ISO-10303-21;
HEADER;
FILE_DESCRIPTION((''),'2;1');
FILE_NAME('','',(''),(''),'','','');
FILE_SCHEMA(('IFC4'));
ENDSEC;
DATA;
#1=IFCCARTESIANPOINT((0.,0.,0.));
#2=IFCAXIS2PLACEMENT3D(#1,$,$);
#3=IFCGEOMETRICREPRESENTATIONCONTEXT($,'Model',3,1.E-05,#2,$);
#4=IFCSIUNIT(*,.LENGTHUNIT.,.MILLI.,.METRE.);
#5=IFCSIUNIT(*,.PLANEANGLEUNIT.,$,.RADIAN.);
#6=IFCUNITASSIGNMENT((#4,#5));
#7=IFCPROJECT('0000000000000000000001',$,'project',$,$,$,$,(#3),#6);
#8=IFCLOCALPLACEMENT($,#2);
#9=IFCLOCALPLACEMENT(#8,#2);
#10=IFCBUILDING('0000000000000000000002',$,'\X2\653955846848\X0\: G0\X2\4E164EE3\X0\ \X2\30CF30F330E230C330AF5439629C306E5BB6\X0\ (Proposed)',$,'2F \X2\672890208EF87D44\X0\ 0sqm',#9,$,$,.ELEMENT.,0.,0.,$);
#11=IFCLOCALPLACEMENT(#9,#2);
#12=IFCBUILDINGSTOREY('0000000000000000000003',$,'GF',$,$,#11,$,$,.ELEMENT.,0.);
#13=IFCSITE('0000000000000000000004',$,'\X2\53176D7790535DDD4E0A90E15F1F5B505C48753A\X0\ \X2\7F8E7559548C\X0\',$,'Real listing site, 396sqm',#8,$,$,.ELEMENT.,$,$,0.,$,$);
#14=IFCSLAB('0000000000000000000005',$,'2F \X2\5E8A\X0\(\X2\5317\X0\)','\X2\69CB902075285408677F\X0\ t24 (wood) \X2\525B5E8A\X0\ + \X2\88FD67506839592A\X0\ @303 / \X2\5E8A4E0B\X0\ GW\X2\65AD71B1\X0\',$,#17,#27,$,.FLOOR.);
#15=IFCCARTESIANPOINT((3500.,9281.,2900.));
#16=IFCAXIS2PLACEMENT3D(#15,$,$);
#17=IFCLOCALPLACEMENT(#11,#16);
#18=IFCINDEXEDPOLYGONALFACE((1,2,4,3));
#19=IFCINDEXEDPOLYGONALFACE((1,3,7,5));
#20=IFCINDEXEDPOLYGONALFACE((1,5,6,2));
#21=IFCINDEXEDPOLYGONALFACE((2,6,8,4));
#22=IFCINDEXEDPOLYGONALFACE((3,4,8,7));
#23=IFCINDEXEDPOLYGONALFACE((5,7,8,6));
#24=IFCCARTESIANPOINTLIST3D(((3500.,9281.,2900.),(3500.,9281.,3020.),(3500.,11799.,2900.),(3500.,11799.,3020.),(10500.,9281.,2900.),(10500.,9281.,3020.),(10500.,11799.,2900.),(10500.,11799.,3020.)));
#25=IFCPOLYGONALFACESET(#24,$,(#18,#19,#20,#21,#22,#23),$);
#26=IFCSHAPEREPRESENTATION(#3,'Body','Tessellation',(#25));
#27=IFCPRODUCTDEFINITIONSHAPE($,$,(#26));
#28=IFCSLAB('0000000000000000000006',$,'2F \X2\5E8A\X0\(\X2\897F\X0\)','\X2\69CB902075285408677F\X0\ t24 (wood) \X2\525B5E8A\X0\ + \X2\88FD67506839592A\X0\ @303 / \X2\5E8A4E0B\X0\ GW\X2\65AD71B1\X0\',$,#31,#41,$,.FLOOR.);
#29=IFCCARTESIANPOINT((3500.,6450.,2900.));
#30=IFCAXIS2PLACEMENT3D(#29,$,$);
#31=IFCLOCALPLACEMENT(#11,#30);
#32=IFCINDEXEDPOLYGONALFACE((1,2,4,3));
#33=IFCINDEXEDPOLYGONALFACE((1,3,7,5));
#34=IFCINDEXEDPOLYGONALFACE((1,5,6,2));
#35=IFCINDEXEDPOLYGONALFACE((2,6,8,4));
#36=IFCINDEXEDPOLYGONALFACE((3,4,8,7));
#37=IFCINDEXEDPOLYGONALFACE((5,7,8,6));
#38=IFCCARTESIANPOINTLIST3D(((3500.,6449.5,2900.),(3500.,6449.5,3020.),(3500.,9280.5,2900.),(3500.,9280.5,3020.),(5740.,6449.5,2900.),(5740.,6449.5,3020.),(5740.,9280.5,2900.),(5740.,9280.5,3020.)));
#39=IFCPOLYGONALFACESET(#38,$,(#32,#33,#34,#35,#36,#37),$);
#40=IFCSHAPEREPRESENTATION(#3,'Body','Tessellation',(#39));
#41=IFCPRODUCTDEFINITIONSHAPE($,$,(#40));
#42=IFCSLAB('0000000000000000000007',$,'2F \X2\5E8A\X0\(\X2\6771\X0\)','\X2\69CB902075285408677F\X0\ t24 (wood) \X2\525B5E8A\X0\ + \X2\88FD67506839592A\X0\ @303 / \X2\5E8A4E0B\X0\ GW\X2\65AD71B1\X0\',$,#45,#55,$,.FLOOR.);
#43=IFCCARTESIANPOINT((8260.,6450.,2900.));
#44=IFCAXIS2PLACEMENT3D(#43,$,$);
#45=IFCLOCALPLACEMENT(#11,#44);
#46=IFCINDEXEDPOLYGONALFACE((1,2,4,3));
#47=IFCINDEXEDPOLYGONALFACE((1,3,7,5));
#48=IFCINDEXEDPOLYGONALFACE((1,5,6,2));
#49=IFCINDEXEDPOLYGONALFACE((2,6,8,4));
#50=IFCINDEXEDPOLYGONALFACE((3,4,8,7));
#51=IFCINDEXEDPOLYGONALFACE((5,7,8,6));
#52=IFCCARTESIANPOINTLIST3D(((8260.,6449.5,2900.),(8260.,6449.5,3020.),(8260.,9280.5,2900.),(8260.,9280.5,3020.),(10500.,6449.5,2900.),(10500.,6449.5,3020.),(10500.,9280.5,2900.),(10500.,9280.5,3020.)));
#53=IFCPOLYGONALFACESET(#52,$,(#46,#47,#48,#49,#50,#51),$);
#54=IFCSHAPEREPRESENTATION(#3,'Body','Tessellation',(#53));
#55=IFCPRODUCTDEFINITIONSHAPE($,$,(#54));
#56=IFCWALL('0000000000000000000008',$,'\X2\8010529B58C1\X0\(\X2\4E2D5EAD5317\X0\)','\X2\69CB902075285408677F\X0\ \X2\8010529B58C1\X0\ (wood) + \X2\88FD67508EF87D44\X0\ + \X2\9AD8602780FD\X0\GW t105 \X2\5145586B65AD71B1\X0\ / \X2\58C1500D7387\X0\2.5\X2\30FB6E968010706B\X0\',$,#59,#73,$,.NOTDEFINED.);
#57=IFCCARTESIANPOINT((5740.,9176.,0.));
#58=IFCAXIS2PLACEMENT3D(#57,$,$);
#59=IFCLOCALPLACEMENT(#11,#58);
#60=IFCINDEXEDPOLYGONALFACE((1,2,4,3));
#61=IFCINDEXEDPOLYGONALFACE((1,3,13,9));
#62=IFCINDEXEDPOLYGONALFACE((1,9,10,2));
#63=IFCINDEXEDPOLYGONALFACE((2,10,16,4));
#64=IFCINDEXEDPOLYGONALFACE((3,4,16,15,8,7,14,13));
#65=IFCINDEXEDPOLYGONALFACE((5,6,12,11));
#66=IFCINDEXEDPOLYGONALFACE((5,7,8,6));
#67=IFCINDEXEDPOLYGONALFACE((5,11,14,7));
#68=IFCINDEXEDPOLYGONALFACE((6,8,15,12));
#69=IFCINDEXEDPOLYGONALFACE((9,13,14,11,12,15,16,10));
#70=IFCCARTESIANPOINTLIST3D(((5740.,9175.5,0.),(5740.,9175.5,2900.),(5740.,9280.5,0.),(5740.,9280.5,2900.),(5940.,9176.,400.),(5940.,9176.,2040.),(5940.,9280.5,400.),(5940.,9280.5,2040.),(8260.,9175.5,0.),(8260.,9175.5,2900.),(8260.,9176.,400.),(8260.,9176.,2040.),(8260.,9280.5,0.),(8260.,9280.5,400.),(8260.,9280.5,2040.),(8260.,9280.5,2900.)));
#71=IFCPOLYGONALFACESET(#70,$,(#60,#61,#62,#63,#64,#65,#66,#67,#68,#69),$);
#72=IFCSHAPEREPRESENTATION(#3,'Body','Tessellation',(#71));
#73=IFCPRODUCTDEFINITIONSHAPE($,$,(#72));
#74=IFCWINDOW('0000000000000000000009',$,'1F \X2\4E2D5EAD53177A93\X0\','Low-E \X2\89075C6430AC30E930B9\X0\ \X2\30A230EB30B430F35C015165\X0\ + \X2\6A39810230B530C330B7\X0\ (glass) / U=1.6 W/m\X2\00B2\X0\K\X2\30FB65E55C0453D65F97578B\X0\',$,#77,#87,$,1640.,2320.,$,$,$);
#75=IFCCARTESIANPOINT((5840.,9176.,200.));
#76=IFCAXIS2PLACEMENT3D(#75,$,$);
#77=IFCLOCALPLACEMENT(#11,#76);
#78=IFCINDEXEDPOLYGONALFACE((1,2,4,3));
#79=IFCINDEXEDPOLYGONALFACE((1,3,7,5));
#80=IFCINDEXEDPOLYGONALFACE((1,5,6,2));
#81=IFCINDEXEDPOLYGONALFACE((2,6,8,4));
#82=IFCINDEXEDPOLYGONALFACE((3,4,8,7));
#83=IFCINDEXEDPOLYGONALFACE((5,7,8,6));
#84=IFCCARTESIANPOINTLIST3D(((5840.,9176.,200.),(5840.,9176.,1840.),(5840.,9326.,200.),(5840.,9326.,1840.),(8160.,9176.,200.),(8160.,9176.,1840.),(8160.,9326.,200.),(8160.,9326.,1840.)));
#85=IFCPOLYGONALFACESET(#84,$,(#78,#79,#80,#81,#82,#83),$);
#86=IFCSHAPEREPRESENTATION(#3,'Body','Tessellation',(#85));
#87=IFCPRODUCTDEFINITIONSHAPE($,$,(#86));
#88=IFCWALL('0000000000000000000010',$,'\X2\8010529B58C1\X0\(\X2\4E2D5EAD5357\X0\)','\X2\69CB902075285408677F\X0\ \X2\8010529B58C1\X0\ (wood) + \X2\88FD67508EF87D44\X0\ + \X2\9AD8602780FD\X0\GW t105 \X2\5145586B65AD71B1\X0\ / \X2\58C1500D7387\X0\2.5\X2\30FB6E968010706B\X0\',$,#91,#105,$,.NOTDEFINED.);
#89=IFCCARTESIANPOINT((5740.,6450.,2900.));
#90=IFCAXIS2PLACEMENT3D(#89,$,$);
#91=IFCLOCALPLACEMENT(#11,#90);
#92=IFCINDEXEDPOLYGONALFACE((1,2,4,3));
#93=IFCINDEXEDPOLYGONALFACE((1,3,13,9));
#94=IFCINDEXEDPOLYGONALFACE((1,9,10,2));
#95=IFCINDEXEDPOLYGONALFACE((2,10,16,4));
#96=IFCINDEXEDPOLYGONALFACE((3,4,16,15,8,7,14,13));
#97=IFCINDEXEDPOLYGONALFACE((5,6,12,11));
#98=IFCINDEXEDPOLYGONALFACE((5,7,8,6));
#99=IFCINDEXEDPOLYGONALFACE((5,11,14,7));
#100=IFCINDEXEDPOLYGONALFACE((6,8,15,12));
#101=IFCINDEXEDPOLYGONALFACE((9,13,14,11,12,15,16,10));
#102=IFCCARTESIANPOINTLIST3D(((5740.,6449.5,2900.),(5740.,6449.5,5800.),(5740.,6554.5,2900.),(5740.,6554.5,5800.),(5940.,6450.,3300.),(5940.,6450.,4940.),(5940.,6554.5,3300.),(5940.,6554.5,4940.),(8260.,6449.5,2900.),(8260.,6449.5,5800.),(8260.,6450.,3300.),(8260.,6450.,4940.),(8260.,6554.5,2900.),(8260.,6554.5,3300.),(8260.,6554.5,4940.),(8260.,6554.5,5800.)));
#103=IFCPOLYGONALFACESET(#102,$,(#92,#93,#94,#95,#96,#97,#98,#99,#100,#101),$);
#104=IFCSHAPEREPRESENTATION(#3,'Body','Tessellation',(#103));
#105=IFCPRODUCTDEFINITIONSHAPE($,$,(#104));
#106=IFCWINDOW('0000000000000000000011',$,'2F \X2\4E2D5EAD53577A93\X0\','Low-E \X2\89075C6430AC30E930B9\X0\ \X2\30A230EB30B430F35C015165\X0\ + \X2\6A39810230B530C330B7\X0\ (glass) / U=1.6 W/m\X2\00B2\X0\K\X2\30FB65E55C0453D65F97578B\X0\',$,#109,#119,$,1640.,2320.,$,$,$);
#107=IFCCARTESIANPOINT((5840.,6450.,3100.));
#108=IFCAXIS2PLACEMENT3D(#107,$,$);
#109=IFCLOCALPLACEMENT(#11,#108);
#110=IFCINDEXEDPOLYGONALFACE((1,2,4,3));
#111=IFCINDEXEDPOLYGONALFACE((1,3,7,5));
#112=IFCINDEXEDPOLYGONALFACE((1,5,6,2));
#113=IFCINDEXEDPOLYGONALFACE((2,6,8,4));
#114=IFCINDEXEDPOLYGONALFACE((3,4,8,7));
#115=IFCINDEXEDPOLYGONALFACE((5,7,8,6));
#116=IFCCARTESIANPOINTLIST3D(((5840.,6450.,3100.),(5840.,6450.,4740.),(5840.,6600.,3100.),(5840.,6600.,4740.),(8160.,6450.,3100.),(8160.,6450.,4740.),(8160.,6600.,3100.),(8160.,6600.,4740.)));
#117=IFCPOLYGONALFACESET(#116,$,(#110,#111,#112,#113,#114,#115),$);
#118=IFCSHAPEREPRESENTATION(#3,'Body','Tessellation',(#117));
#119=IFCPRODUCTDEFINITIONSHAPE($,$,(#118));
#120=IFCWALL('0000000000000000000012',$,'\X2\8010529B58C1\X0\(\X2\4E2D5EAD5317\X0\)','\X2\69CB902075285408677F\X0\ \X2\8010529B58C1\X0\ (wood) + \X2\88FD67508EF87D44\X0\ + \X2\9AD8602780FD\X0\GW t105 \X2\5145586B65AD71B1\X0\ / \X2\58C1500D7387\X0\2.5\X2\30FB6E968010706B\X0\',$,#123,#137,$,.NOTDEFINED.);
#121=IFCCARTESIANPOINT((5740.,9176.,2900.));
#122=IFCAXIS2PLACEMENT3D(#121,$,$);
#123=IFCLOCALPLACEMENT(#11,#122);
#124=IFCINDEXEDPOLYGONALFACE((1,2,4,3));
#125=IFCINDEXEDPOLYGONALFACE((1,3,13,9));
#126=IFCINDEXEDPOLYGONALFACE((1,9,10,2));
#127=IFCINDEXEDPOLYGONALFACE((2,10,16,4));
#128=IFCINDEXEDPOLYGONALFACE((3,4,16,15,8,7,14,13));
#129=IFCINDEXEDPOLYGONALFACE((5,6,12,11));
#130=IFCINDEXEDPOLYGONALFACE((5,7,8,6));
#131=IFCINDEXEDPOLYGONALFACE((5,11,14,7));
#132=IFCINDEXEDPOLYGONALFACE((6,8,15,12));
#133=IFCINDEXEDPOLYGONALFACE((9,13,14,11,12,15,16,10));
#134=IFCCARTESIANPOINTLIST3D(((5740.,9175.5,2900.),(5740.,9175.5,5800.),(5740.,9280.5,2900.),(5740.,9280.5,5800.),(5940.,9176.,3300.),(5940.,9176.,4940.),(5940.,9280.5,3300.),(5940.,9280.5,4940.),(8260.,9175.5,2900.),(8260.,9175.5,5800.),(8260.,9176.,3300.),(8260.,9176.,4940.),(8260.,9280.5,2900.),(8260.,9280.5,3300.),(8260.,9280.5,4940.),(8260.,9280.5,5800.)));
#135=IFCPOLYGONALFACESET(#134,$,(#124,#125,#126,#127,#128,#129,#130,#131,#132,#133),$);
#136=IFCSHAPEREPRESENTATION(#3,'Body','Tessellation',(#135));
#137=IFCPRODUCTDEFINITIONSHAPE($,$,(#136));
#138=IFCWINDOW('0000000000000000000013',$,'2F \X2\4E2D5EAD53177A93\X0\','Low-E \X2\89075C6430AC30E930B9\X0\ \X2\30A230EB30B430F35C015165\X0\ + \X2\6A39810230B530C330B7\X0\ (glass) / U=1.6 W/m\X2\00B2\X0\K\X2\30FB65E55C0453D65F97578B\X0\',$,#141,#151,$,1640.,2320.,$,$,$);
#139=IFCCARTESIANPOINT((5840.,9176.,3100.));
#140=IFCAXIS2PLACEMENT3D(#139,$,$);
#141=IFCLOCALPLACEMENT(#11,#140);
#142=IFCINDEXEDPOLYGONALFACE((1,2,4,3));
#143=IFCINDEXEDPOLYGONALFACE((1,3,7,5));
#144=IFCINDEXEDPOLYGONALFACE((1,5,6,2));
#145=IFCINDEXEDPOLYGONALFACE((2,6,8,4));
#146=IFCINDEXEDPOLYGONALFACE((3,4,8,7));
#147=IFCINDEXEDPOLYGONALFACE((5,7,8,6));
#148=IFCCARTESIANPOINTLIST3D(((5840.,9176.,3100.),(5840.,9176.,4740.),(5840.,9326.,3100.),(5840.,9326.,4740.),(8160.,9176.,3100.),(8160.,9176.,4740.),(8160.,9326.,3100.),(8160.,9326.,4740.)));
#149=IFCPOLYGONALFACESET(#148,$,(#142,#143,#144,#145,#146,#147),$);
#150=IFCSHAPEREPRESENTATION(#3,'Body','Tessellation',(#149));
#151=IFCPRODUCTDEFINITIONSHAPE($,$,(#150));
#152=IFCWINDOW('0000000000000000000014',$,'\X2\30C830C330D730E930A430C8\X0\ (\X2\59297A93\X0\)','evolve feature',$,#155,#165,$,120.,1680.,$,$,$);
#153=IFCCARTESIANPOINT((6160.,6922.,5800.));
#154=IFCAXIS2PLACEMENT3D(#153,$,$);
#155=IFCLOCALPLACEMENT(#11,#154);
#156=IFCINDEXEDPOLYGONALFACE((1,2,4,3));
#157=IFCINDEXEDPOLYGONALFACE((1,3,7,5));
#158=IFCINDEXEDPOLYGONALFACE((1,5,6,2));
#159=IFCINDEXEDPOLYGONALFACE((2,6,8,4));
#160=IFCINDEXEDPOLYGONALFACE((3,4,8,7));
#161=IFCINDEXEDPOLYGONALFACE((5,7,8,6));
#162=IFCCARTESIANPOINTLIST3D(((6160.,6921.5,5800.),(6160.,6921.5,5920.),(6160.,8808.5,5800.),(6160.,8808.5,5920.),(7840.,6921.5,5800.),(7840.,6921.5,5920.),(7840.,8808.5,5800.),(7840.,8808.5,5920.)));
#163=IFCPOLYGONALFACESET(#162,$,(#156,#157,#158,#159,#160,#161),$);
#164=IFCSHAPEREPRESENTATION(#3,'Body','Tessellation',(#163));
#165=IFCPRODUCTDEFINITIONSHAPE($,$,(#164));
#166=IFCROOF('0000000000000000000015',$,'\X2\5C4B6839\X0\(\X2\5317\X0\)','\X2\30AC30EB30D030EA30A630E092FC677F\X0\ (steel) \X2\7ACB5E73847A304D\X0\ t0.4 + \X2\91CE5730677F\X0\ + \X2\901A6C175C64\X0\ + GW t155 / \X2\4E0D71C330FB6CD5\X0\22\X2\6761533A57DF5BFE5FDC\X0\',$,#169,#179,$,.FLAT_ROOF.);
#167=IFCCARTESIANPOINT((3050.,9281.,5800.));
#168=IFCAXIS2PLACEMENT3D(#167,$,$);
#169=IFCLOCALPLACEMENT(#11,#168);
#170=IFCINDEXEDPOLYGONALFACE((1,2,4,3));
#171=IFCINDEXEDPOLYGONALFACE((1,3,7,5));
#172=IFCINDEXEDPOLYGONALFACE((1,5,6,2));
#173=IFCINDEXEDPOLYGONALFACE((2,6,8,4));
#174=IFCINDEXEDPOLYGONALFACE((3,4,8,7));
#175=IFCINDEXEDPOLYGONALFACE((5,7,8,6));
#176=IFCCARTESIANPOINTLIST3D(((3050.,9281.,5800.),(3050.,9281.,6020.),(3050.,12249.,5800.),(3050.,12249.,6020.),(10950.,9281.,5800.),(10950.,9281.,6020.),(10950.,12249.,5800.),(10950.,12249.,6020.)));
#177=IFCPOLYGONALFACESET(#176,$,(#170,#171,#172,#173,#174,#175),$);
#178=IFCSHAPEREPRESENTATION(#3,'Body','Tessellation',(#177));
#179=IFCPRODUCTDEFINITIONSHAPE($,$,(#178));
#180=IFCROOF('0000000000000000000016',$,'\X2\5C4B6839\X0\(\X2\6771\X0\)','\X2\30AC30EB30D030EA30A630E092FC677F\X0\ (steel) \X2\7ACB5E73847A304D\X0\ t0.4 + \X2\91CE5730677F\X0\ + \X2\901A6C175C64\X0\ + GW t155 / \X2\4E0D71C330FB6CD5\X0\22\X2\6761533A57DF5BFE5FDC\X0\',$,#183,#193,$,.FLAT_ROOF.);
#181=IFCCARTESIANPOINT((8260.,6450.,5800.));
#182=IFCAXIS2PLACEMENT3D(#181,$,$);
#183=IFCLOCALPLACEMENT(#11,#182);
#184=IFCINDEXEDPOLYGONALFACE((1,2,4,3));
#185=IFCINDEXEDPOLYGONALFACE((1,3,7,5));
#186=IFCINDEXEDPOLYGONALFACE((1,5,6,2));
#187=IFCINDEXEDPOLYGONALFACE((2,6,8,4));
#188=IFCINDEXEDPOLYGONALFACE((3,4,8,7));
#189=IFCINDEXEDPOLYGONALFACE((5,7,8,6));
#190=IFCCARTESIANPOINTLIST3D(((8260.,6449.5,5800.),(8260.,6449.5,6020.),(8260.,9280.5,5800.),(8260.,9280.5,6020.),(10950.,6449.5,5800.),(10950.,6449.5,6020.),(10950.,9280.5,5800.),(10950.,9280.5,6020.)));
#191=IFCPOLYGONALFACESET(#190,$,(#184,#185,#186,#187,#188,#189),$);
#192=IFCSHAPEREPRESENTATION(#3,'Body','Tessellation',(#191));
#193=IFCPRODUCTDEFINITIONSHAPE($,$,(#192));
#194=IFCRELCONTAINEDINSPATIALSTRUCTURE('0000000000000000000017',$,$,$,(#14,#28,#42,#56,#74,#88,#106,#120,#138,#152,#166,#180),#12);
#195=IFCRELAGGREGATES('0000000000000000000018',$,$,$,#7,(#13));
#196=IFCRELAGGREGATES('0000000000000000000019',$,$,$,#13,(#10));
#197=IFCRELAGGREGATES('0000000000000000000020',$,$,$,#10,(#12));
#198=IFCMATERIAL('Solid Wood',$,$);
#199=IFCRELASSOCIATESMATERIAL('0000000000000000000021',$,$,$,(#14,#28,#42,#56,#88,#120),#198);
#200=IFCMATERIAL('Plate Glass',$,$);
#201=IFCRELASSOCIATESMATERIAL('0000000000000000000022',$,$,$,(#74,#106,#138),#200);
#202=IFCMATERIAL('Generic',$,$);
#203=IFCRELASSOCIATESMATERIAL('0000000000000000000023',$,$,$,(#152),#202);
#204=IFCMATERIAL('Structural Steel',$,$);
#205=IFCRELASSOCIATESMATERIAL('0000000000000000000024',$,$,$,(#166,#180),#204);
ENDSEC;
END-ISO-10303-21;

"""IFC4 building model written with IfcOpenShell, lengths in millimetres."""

from ifc_helpers import new_model, si_unit, frame, frame_2d, origin, place, context, project, spatial, rectangle, extrude, material, element, fill, save


model = new_model("IFC4")

# Units and contexts
model_context = context("Model", 3, precision=1e-05, world=origin())
ifc_project = project(units=[si_unit("LENGTHUNIT", "METRE", prefix="MILLI"), si_unit("PLANEANGLEUNIT", "RADIAN")], contexts=[model_context])

# Site, building, storey
site_placement = place(None, origin())
site = spatial("IfcSite", under=ifc_project, at=site_placement, Name="北海道川上郡弟子屈町 美留和", ObjectType="Real listing site, 396sqm", CompositionType="ELEMENT", RefElevation=0.0)
building_placement = place(site_placement, origin())
building = spatial("IfcBuilding", under=site, at=building_placement, Name="改善案: G0世代 ハンモック吹抜の家 (Proposed)", ObjectType="2F 木造軸組 0sqm", CompositionType="ELEMENT", ElevationOfRefHeight=0.0, ElevationOfTerrain=0.0)
storey_placement = place(building_placement, origin())
storey = spatial("IfcBuildingStorey", under=building, at=storey_placement, Name="GF", CompositionType="ELEMENT", Elevation=0.0)

# Slabs
ifc_material_1 = material(Name="Solid Wood")
slab_1_placement = place(storey_placement, frame((3500.0, 9281.0, 2900.0)))
element("IfcSlab", 1, at=slab_1_placement, inside=storey, material=ifc_material_1, Name="2F 床(北)", Description="構造用合板 t24 (wood) 剛床 + 製材根太 @303 / 床下 GW断熱", PredefinedType="FLOOR", context=model_context, shape_type="SweptSolid", body=[
    extrude(rectangle(XDim=7000.0, YDim=2518.0, at=frame_2d((3500.0, 1259.0))), frame((3500.0, 9281.0, 2900.0)), (0.0, 0.0, 1.0), 120.0),
])
slab_2_placement = place(storey_placement, frame((3500.0, 6450.0, 2900.0)))
element("IfcSlab", 2, at=slab_2_placement, inside=storey, material=ifc_material_1, Name="2F 床(西)", Description="構造用合板 t24 (wood) 剛床 + 製材根太 @303 / 床下 GW断熱", PredefinedType="FLOOR", context=model_context, shape_type="SweptSolid", body=[
    extrude(rectangle(XDim=2240.0, YDim=2831.0, at=frame_2d((1120.0, 1415.0))), frame((3500.0, 6450.0, 2900.0)), (0.0, 0.0, 1.0), 120.0),
])
slab_3_placement = place(storey_placement, frame((8260.0, 6450.0, 2900.0)))
element("IfcSlab", 3, at=slab_3_placement, inside=storey, material=ifc_material_1, Name="2F 床(東)", Description="構造用合板 t24 (wood) 剛床 + 製材根太 @303 / 床下 GW断熱", PredefinedType="FLOOR", context=model_context, shape_type="SweptSolid", body=[
    extrude(rectangle(XDim=2240.0, YDim=2831.0, at=frame_2d((1120.0, 1415.0))), frame((8260.0, 6450.0, 2900.0)), (0.0, 0.0, 1.0), 120.0),
])

# Wall, opening, window
wall_1_placement = place(storey_placement, frame((5740.0, 9176.0, 0.0)))
wall_1 = element("IfcWall", 4, at=wall_1_placement, inside=storey, material=ifc_material_1, Name="耐力壁(中庭北)", Description="構造用合板 耐力壁 (wood) + 製材軸組 + 高性能GW t105 充填断熱 / 壁倍率2.5・準耐火", PredefinedType="NOTDEFINED", context=model_context, shape_type="SweptSolid", body=[
    extrude(rectangle(XDim=2520.0, YDim=105.0, at=frame_2d((1260.0, 52.0))), frame((5740.0, 9176.0, 0.0)), (0.0, 0.0, 1.0), 2900.0),
])
opening_1_placement = place(storey_placement, frame((5840.0, 9176.0, 200.0)))
opening_1 = element("IfcOpeningElement", 5, at=opening_1_placement, cuts=wall_1, PredefinedType="NOTDEFINED", context=model_context, shape_type="SweptSolid", body=[
    extrude(rectangle(XDim=2320.0, YDim=150.0, at=frame_2d((1160.0, 75.0))), frame((5840.0, 9176.0, 200.0)), (0.0, 0.0, 1.0), 1640.0),
])
ifc_material_2 = material(Name="Plate Glass")
window_1_placement = place(storey_placement, frame((5840.0, 9176.0, 200.0)))
window_1 = element("IfcWindow", 6, at=window_1_placement, inside=storey, material=ifc_material_2, Name="1F 中庭北窓", Description="Low-E 複層ガラス アルゴン封入 + 樹脂サッシ (glass) / U=1.6 W/m²K・日射取得型", OverallHeight=1640.0, OverallWidth=2320.0, context=model_context, shape_type="SweptSolid", body=[
    extrude(rectangle(XDim=2320.0, YDim=150.0, at=frame_2d((1160.0, 75.0))), frame((5840.0, 9176.0, 200.0)), (0.0, 0.0, 1.0), 1640.0),
])
fill(opening_1, window_1)

# Walls, openings, windows
wall_2_placement = place(storey_placement, frame((5740.0, 6450.0, 2900.0)))
wall_2 = element("IfcWall", 7, at=wall_2_placement, inside=storey, material=ifc_material_1, Name="耐力壁(中庭南)", Description="構造用合板 耐力壁 (wood) + 製材軸組 + 高性能GW t105 充填断熱 / 壁倍率2.5・準耐火", PredefinedType="NOTDEFINED", context=model_context, shape_type="SweptSolid", body=[
    extrude(rectangle(XDim=2520.0, YDim=105.0, at=frame_2d((1260.0, 52.0))), frame((5740.0, 6450.0, 2900.0)), (0.0, 0.0, 1.0), 2900.0),
])
opening_2_placement = place(storey_placement, frame((5840.0, 6450.0, 3100.0)))
opening_2 = element("IfcOpeningElement", 8, at=opening_2_placement, cuts=wall_2, PredefinedType="NOTDEFINED", context=model_context, shape_type="SweptSolid", body=[
    extrude(rectangle(XDim=2320.0, YDim=150.0, at=frame_2d((1160.0, 75.0))), frame((5840.0, 6450.0, 3100.0)), (0.0, 0.0, 1.0), 1640.0),
])
window_2_placement = place(storey_placement, frame((5840.0, 6450.0, 3100.0)))
window_2 = element("IfcWindow", 9, at=window_2_placement, inside=storey, material=ifc_material_2, Name="2F 中庭南窓", Description="Low-E 複層ガラス アルゴン封入 + 樹脂サッシ (glass) / U=1.6 W/m²K・日射取得型", OverallHeight=1640.0, OverallWidth=2320.0, context=model_context, shape_type="SweptSolid", body=[
    extrude(rectangle(XDim=2320.0, YDim=150.0, at=frame_2d((1160.0, 75.0))), frame((5840.0, 6450.0, 3100.0)), (0.0, 0.0, 1.0), 1640.0),
])
fill(opening_2, window_2)
wall_3_placement = place(storey_placement, frame((5740.0, 9176.0, 2900.0)))
wall_3 = element("IfcWall", 10, at=wall_3_placement, inside=storey, material=ifc_material_1, Name="耐力壁(中庭北)", Description="構造用合板 耐力壁 (wood) + 製材軸組 + 高性能GW t105 充填断熱 / 壁倍率2.5・準耐火", PredefinedType="NOTDEFINED", context=model_context, shape_type="SweptSolid", body=[
    extrude(rectangle(XDim=2520.0, YDim=105.0, at=frame_2d((1260.0, 52.0))), frame((5740.0, 9176.0, 2900.0)), (0.0, 0.0, 1.0), 2900.0),
])
opening_3_placement = place(storey_placement, frame((5840.0, 9176.0, 3100.0)))
opening_3 = element("IfcOpeningElement", 11, at=opening_3_placement, cuts=wall_3, PredefinedType="NOTDEFINED", context=model_context, shape_type="SweptSolid", body=[
    extrude(rectangle(XDim=2320.0, YDim=150.0, at=frame_2d((1160.0, 75.0))), frame((5840.0, 9176.0, 3100.0)), (0.0, 0.0, 1.0), 1640.0),
])
window_3_placement = place(storey_placement, frame((5840.0, 9176.0, 3100.0)))
window_3 = element("IfcWindow", 12, at=window_3_placement, inside=storey, material=ifc_material_2, Name="2F 中庭北窓", Description="Low-E 複層ガラス アルゴン封入 + 樹脂サッシ (glass) / U=1.6 W/m²K・日射取得型", OverallHeight=1640.0, OverallWidth=2320.0, context=model_context, shape_type="SweptSolid", body=[
    extrude(rectangle(XDim=2320.0, YDim=150.0, at=frame_2d((1160.0, 75.0))), frame((5840.0, 9176.0, 3100.0)), (0.0, 0.0, 1.0), 1640.0),
])
fill(opening_3, window_3)

# Window
ifc_material_3 = material(Name="Generic")
window_4_placement = place(storey_placement, frame((6160.0, 6922.0, 5800.0)))
element("IfcWindow", 13, at=window_4_placement, inside=storey, material=ifc_material_3, Name="トップライト (天窓)", Description="evolve feature", OverallHeight=120.0, OverallWidth=1680.0, context=model_context, shape_type="SweptSolid", body=[
    extrude(rectangle(XDim=1680.0, YDim=1887.0, at=frame_2d((840.0, 943.0))), frame((6160.0, 6922.0, 5800.0)), (0.0, 0.0, 1.0), 120.0),
])

# Roofs
ifc_material_4 = material(Name="Structural Steel")
roof_1_placement = place(storey_placement, frame((3050.0, 9281.0, 5800.0)))
element("IfcRoof", 14, at=roof_1_placement, inside=storey, material=ifc_material_4, Name="屋根(北)", Description="ガルバリウム鋼板 (steel) 立平葺き t0.4 + 野地板 + 通気層 + GW t155 / 不燃・法22条区域対応", PredefinedType="FLAT_ROOF", context=model_context, shape_type="SweptSolid", body=[
    extrude(rectangle(XDim=7900.0, YDim=2968.0, at=frame_2d((3950.0, 1484.0))), frame((3050.0, 9281.0, 5800.0)), (0.0, 0.0, 1.0), 220.0),
])
roof_2_placement = place(storey_placement, frame((8260.0, 6450.0, 5800.0)))
element("IfcRoof", 15, at=roof_2_placement, inside=storey, material=ifc_material_4, Name="屋根(東)", Description="ガルバリウム鋼板 (steel) 立平葺き t0.4 + 野地板 + 通気層 + GW t155 / 不燃・法22条区域対応", PredefinedType="FLAT_ROOF", context=model_context, shape_type="SweptSolid", body=[
    extrude(rectangle(XDim=2690.0, YDim=2831.0, at=frame_2d((1345.0, 1415.0))), frame((8260.0, 6450.0, 5800.0)), (0.0, 0.0, 1.0), 220.0),
])

save(model, "model.ifc")
